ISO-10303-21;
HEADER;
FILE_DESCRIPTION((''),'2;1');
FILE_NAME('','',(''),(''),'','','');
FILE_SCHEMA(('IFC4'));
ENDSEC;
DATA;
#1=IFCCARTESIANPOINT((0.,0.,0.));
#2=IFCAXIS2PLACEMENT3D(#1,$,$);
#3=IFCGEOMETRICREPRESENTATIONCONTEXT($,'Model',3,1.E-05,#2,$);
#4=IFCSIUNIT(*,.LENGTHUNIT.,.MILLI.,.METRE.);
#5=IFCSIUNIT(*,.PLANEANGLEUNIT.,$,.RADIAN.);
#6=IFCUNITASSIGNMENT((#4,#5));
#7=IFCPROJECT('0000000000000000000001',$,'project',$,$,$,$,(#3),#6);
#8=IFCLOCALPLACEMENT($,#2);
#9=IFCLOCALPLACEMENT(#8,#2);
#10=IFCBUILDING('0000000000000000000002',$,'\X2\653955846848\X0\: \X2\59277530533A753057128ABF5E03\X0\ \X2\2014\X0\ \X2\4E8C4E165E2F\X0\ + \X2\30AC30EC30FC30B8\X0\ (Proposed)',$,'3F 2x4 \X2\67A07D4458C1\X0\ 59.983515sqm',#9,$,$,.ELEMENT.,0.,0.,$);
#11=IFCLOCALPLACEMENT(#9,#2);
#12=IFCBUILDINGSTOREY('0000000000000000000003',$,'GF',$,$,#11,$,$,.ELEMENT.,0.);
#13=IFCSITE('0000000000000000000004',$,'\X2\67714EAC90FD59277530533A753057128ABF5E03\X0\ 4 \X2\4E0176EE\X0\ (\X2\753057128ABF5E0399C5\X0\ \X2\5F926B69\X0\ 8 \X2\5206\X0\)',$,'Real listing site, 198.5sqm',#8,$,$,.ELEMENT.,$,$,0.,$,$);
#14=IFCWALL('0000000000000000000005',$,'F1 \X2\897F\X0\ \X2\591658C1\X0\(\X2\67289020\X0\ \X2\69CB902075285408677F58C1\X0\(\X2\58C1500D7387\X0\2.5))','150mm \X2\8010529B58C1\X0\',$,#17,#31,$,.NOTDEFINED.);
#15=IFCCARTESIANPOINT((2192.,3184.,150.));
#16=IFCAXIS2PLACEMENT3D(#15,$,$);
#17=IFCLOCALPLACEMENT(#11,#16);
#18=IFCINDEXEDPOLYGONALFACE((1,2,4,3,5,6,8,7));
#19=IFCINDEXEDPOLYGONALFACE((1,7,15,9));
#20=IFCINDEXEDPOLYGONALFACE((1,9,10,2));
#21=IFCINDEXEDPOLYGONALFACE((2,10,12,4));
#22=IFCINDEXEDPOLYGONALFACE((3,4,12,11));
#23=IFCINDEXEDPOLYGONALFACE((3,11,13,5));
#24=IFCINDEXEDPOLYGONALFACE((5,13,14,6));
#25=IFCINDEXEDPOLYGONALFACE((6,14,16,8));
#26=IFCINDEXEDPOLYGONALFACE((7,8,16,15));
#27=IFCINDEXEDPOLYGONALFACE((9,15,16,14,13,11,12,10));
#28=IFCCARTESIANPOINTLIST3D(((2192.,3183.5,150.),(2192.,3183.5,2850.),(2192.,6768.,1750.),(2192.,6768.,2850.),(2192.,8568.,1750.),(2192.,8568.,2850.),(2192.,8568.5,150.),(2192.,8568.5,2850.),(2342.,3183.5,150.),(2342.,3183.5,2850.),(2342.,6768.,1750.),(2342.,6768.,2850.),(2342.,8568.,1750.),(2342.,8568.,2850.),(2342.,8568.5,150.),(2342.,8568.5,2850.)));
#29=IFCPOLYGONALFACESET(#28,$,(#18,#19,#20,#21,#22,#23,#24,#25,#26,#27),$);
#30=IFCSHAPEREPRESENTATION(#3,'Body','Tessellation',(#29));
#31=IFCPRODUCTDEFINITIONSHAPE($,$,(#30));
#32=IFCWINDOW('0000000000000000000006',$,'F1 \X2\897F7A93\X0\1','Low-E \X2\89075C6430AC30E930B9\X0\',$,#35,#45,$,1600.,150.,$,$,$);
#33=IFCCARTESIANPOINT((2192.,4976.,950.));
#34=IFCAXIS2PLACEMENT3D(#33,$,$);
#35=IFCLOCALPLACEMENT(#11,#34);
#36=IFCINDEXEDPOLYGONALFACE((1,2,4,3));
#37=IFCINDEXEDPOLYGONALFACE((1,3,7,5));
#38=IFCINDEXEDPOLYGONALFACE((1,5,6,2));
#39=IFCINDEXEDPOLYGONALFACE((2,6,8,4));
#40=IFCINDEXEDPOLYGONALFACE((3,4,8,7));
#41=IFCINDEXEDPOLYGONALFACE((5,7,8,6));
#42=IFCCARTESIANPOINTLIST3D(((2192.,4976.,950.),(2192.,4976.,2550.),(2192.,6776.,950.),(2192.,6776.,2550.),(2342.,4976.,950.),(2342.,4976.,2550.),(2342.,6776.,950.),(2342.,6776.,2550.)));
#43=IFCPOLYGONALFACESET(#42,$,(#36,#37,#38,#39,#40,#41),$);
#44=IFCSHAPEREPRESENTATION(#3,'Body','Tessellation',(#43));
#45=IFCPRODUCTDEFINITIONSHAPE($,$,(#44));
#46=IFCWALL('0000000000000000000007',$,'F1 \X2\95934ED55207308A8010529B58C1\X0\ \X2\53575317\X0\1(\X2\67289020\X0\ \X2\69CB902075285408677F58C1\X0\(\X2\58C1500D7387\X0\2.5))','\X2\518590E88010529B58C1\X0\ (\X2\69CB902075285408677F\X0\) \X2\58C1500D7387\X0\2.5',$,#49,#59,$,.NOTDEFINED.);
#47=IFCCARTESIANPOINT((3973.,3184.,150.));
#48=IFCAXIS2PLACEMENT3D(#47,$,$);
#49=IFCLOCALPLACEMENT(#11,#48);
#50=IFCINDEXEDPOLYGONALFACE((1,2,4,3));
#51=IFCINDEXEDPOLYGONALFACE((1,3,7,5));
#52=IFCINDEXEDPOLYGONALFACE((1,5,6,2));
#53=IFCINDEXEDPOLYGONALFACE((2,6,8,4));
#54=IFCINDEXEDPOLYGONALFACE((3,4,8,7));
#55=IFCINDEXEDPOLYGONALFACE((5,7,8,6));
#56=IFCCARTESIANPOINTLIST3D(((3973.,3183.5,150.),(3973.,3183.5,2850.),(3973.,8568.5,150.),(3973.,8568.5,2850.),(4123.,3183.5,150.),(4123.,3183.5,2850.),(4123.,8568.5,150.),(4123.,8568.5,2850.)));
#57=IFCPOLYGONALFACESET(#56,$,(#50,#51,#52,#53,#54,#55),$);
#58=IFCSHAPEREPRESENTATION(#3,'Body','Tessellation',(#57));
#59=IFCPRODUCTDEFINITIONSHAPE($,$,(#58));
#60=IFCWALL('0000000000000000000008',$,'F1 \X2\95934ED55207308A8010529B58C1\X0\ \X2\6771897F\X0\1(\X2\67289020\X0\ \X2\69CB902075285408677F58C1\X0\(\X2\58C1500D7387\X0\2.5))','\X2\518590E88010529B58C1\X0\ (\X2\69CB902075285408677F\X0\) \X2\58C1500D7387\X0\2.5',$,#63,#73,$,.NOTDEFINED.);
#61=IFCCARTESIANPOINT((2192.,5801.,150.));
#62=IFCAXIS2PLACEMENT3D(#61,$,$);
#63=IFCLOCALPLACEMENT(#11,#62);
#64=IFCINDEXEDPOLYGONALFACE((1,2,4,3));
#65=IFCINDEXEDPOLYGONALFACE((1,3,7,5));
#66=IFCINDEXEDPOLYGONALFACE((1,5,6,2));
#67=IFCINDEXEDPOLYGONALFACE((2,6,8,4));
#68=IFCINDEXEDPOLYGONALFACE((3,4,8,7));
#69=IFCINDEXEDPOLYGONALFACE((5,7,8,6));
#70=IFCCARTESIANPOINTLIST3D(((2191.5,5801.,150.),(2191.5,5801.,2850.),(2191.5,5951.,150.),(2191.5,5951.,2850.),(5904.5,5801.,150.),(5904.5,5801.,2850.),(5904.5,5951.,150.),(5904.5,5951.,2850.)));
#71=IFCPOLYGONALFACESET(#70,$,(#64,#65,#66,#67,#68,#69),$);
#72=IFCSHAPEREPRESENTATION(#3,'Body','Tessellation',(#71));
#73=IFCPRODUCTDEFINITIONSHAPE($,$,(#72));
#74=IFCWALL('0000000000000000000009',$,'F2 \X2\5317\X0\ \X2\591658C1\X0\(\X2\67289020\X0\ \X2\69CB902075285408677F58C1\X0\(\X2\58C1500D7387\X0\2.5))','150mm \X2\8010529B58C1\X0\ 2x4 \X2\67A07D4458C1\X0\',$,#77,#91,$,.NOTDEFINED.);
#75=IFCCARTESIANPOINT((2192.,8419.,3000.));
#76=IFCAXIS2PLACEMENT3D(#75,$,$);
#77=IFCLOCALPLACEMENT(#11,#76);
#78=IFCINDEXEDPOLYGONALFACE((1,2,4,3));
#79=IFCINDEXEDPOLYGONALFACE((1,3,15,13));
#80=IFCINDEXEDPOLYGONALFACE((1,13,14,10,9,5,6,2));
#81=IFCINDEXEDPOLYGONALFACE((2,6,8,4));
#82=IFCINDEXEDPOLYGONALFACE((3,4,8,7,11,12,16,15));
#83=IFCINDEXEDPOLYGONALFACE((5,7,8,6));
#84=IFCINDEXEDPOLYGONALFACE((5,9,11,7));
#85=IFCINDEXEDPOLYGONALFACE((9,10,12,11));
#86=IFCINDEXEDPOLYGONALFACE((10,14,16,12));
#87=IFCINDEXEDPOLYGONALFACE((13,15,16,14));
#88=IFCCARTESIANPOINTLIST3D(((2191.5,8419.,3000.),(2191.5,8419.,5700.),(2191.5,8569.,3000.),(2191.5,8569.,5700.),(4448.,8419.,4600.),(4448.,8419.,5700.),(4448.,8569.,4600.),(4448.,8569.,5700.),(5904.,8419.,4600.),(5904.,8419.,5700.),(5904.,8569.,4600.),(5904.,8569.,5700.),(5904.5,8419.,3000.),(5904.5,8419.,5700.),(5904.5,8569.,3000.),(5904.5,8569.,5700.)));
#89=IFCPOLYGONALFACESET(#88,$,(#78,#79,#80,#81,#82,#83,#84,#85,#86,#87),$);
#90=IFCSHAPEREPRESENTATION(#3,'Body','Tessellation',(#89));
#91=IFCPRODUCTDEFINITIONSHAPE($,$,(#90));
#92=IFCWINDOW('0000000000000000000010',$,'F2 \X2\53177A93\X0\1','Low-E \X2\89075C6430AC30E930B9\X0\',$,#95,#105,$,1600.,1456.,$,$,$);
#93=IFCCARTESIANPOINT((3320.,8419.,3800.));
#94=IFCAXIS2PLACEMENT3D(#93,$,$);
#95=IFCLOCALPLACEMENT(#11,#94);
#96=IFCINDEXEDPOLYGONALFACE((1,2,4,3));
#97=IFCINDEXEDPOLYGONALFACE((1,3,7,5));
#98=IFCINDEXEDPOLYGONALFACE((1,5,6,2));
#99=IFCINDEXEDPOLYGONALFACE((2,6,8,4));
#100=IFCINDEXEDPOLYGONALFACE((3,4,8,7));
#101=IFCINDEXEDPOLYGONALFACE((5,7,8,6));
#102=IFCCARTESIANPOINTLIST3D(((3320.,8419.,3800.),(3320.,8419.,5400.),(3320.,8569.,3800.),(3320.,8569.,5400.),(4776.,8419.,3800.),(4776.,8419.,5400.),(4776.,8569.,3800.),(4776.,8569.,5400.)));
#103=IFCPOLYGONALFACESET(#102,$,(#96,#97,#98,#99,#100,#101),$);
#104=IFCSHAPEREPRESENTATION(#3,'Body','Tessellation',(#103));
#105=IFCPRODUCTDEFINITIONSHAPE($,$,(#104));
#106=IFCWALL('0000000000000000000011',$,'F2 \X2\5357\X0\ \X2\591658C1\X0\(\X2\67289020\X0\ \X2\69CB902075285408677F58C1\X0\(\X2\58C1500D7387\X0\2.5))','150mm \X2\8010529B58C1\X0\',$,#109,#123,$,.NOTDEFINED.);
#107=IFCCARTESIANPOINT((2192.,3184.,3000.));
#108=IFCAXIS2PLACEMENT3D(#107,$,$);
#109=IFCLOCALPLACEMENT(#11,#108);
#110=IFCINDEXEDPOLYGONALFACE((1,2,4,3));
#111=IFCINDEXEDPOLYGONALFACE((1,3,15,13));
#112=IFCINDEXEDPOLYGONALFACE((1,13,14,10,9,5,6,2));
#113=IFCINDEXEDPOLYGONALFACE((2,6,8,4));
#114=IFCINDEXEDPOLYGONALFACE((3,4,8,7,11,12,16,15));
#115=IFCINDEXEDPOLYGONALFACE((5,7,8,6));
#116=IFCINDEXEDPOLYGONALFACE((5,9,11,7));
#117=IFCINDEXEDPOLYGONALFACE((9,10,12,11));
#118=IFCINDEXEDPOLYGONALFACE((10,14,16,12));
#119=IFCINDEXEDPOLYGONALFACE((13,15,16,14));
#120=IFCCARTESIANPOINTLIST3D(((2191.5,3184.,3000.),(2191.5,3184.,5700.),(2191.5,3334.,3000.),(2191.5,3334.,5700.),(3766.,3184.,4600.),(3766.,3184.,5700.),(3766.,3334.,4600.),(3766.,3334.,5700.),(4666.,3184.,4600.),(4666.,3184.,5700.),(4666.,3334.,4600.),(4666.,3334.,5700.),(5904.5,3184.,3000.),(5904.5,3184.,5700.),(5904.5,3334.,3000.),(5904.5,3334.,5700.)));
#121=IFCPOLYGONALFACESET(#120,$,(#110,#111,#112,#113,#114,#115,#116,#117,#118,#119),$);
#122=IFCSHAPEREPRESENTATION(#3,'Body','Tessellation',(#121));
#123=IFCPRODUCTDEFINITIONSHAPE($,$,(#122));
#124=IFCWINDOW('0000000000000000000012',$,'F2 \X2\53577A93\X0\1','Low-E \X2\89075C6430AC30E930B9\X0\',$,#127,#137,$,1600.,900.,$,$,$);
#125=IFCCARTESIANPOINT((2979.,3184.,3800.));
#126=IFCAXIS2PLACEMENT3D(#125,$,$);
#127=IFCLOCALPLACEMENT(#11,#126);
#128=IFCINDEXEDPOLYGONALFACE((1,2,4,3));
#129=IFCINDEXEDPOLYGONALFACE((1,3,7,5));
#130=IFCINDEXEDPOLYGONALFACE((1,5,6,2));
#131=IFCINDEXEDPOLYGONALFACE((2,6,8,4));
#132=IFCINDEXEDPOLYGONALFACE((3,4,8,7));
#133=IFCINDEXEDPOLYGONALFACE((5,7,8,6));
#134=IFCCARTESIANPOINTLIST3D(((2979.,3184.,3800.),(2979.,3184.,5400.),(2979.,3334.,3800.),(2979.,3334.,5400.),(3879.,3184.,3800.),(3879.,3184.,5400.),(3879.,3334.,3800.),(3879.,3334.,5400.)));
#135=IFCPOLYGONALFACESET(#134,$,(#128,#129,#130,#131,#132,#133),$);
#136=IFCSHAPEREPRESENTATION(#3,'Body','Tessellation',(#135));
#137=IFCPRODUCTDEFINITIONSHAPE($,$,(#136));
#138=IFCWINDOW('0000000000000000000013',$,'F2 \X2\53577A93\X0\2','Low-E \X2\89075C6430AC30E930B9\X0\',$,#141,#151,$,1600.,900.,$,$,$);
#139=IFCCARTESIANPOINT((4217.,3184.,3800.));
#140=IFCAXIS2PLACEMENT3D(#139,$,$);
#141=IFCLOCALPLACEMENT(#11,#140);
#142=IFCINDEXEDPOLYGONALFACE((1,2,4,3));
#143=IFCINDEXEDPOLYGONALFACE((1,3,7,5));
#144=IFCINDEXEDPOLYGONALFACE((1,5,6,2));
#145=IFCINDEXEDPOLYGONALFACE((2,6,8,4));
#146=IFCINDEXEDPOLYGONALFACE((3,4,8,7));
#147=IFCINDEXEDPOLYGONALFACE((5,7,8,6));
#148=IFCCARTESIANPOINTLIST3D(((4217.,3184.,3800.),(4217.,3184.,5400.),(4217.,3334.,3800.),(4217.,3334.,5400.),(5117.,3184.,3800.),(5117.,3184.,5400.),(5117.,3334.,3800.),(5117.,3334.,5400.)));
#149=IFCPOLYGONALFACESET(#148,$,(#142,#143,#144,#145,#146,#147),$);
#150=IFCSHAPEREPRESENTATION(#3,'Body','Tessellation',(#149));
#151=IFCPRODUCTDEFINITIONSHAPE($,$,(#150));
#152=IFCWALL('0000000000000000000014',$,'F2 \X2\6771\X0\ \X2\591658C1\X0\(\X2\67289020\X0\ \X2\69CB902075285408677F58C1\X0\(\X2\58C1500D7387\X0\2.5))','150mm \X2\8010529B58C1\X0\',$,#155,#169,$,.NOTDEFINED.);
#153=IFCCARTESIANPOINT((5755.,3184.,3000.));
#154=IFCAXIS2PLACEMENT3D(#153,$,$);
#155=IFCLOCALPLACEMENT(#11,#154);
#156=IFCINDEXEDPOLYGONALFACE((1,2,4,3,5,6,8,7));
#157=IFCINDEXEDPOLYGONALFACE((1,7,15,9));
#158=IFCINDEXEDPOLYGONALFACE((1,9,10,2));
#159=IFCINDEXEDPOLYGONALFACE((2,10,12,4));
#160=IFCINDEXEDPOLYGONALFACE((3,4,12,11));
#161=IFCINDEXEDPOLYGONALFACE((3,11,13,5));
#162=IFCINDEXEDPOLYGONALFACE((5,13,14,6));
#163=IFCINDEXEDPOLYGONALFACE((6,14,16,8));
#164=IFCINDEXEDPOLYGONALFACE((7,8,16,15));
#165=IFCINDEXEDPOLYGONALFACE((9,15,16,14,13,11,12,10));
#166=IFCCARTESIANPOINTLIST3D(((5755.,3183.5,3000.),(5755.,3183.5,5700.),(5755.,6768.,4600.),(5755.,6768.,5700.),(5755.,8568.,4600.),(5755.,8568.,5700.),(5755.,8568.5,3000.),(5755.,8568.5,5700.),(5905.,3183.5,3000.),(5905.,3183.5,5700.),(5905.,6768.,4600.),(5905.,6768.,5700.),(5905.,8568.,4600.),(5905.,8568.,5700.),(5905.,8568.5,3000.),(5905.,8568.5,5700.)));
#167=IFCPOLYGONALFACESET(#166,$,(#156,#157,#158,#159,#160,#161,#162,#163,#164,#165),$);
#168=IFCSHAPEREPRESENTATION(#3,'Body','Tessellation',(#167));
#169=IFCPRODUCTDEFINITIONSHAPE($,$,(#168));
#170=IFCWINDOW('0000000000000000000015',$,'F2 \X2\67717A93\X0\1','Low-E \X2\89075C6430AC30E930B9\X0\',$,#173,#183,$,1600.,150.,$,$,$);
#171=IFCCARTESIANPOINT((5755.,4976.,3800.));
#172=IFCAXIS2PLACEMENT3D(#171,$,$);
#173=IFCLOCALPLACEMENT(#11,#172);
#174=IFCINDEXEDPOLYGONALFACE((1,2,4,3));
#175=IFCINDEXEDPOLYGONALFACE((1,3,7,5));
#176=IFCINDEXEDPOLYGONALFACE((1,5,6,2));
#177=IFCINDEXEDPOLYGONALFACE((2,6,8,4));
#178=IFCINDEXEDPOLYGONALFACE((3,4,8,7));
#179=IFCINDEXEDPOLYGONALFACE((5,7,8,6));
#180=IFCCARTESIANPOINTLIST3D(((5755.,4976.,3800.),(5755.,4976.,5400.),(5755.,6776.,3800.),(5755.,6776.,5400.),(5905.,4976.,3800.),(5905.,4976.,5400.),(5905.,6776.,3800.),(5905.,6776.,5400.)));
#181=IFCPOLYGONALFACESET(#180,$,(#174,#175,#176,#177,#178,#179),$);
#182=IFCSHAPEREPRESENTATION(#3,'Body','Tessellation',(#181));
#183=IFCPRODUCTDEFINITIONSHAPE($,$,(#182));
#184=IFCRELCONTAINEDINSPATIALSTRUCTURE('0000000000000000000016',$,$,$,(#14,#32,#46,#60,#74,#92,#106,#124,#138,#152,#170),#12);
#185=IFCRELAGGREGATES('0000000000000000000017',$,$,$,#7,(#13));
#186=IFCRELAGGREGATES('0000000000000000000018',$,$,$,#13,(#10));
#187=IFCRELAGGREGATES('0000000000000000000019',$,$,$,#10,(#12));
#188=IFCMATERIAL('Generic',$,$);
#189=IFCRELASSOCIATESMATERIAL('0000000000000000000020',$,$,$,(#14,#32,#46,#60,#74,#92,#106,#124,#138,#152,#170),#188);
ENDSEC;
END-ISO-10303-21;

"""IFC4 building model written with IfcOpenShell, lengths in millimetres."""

from ifc_helpers import new_model, si_unit, frame, frame_2d, origin, place, context, project, spatial, rectangle, extrude, material, element, fill, save


model = new_model("IFC4")

# Units and contexts
model_context = context("Model", 3, precision=1e-05, world=origin())
ifc_project = project(units=[si_unit("LENGTHUNIT", "METRE", prefix="MILLI"), si_unit("PLANEANGLEUNIT", "RADIAN")], contexts=[model_context])

# Site, building, storey
site_placement = place(None, origin())
site = spatial("IfcSite", under=ifc_project, at=site_placement, Name="東京都大田区田園調布 4 丁目 (田園調布駅 徒歩 8 分)", ObjectType="Real listing site, 198.5sqm", CompositionType="ELEMENT", RefElevation=0.0)
building_placement = place(site_placement, origin())
building = spatial("IfcBuilding", under=site, at=building_placement, Name="改善案: 大田区田園調布 — 二世帯 + ガレージ (Proposed)", ObjectType="3F 2x4 枠組壁 59.983515sqm", CompositionType="ELEMENT", ElevationOfRefHeight=0.0, ElevationOfTerrain=0.0)
storey_placement = place(building_placement, origin())
storey = spatial("IfcBuildingStorey", under=building, at=storey_placement, Name="GF", CompositionType="ELEMENT", Elevation=0.0)

# Shared definitions
ifc_material_1 = material(Name="Generic")

# Wall, opening, window
wall_1_placement = place(storey_placement, frame((2192.0, 3184.0, 150.0)))
wall_1 = element("IfcWall", 1, at=wall_1_placement, inside=storey, material=ifc_material_1, Name="F1 西 外壁(木造 構造用合板壁(壁倍率2.5))", Description="150mm 耐力壁", PredefinedType="NOTDEFINED", context=model_context, shape_type="SweptSolid", body=[
    extrude(rectangle(XDim=150.0, YDim=5385.0, at=frame_2d((75.0, 2692.0))), frame((2192.0, 3184.0, 150.0)), (0.0, 0.0, 1.0), 2700.0),
])
opening_1_placement = place(storey_placement, frame((2192.0, 4976.0, 950.0)))
opening_1 = element("IfcOpeningElement", 2, at=opening_1_placement, cuts=wall_1, PredefinedType="NOTDEFINED", context=model_context, shape_type="SweptSolid", body=[
    extrude(rectangle(XDim=150.0, YDim=1800.0, at=frame_2d((75.0, 900.0))), frame((2192.0, 4976.0, 950.0)), (0.0, 0.0, 1.0), 1600.0),
])
window_1_placement = place(storey_placement, frame((2192.0, 4976.0, 950.0)))
window_1 = element("IfcWindow", 3, at=window_1_placement, inside=storey, material=ifc_material_1, Name="F1 西窓1", Description="Low-E 複層ガラス", OverallHeight=1600.0, OverallWidth=150.0, context=model_context, shape_type="SweptSolid", body=[
    extrude(rectangle(XDim=150.0, YDim=1800.0, at=frame_2d((75.0, 900.0))), frame((2192.0, 4976.0, 950.0)), (0.0, 0.0, 1.0), 1600.0),
])
fill(opening_1, window_1)

# Walls
wall_2_placement = place(storey_placement, frame((3973.0, 3184.0, 150.0)))
element("IfcWall", 4, at=wall_2_placement, inside=storey, material=ifc_material_1, Name="F1 間仕切り耐力壁 南北1(木造 構造用合板壁(壁倍率2.5))", Description="内部耐力壁 (構造用合板) 壁倍率2.5", PredefinedType="NOTDEFINED", context=model_context, shape_type="SweptSolid", body=[
    extrude(rectangle(XDim=150.0, YDim=5385.0, at=frame_2d((75.0, 2692.0))), frame((3973.0, 3184.0, 150.0)), (0.0, 0.0, 1.0), 2700.0),
])
wall_3_placement = place(storey_placement, frame((2192.0, 5801.0, 150.0)))
element("IfcWall", 5, at=wall_3_placement, inside=storey, material=ifc_material_1, Name="F1 間仕切り耐力壁 東西1(木造 構造用合板壁(壁倍率2.5))", Description="内部耐力壁 (構造用合板) 壁倍率2.5", PredefinedType="NOTDEFINED", context=model_context, shape_type="SweptSolid", body=[
    extrude(rectangle(XDim=3713.0, YDim=150.0, at=frame_2d((1856.0, 75.0))), frame((2192.0, 5801.0, 150.0)), (0.0, 0.0, 1.0), 2700.0),
])

# Wall, opening, window
wall_4_placement = place(storey_placement, frame((2192.0, 8419.0, 3000.0)))
wall_4 = element("IfcWall", 6, at=wall_4_placement, inside=storey, material=ifc_material_1, Name="F2 北 外壁(木造 構造用合板壁(壁倍率2.5))", Description="150mm 耐力壁 2x4 枠組壁", PredefinedType="NOTDEFINED", context=model_context, shape_type="SweptSolid", body=[
    extrude(rectangle(XDim=3713.0, YDim=150.0, at=frame_2d((1856.0, 75.0))), frame((2192.0, 8419.0, 3000.0)), (0.0, 0.0, 1.0), 2700.0),
])
opening_2_placement = place(storey_placement, frame((3320.0, 8419.0, 3800.0)))
opening_2 = element("IfcOpeningElement", 7, at=opening_2_placement, cuts=wall_4, PredefinedType="NOTDEFINED", context=model_context, shape_type="SweptSolid", body=[
    extrude(rectangle(XDim=1456.0, YDim=150.0, at=frame_2d((728.0, 75.0))), frame((3320.0, 8419.0, 3800.0)), (0.0, 0.0, 1.0), 1600.0),
])
window_2_placement = place(storey_placement, frame((3320.0, 8419.0, 3800.0)))
window_2 = element("IfcWindow", 8, at=window_2_placement, inside=storey, material=ifc_material_1, Name="F2 北窓1", Description="Low-E 複層ガラス", OverallHeight=1600.0, OverallWidth=1456.0, context=model_context, shape_type="SweptSolid", body=[
    extrude(rectangle(XDim=1456.0, YDim=150.0, at=frame_2d((728.0, 75.0))), frame((3320.0, 8419.0, 3800.0)), (0.0, 0.0, 1.0), 1600.0),
])
fill(opening_2, window_2)

# Wall, openings, windows
wall_5_placement = place(storey_placement, frame((2192.0, 3184.0, 3000.0)))
wall_5 = element("IfcWall", 9, at=wall_5_placement, inside=storey, material=ifc_material_1, Name="F2 南 外壁(木造 構造用合板壁(壁倍率2.5))", Description="150mm 耐力壁", PredefinedType="NOTDEFINED", context=model_context, shape_type="SweptSolid", body=[
    extrude(rectangle(XDim=3713.0, YDim=150.0, at=frame_2d((1856.0, 75.0))), frame((2192.0, 3184.0, 3000.0)), (0.0, 0.0, 1.0), 2700.0),
])
opening_3_placement = place(storey_placement, frame((2979.0, 3184.0, 3800.0)))
opening_3 = element("IfcOpeningElement", 10, at=opening_3_placement, cuts=wall_5, PredefinedType="NOTDEFINED", context=model_context, shape_type="SweptSolid", body=[
    extrude(rectangle(XDim=900.0, YDim=150.0, at=frame_2d((450.0, 75.0))), frame((2979.0, 3184.0, 3800.0)), (0.0, 0.0, 1.0), 1600.0),
])
opening_4_placement = place(storey_placement, frame((4217.0, 3184.0, 3800.0)))
opening_4 = element("IfcOpeningElement", 11, at=opening_4_placement, cuts=wall_5, PredefinedType="NOTDEFINED", context=model_context, shape_type="SweptSolid", body=[
    extrude(rectangle(XDim=900.0, YDim=150.0, at=frame_2d((450.0, 75.0))), frame((4217.0, 3184.0, 3800.0)), (0.0, 0.0, 1.0), 1600.0),
])
window_3_placement = place(storey_placement, frame((2979.0, 3184.0, 3800.0)))
window_3 = element("IfcWindow", 12, at=window_3_placement, inside=storey, material=ifc_material_1, Name="F2 南窓1", Description="Low-E 複層ガラス", OverallHeight=1600.0, OverallWidth=900.0, context=model_context, shape_type="SweptSolid", body=[
    extrude(rectangle(XDim=900.0, YDim=150.0, at=frame_2d((450.0, 75.0))), frame((2979.0, 3184.0, 3800.0)), (0.0, 0.0, 1.0), 1600.0),
])
fill(opening_3, window_3)
window_4_placement = place(storey_placement, frame((4217.0, 3184.0, 3800.0)))
window_4 = element("IfcWindow", 13, at=window_4_placement, inside=storey, material=ifc_material_1, Name="F2 南窓2", Description="Low-E 複層ガラス", OverallHeight=1600.0, OverallWidth=900.0, context=model_context, shape_type="SweptSolid", body=[
    extrude(rectangle(XDim=900.0, YDim=150.0, at=frame_2d((450.0, 75.0))), frame((4217.0, 3184.0, 3800.0)), (0.0, 0.0, 1.0), 1600.0),
])
fill(opening_4, window_4)

# Wall, opening, window
wall_6_placement = place(storey_placement, frame((5755.0, 3184.0, 3000.0)))
wall_6 = element("IfcWall", 14, at=wall_6_placement, inside=storey, material=ifc_material_1, Name="F2 東 外壁(木造 構造用合板壁(壁倍率2.5))", Description="150mm 耐力壁", PredefinedType="NOTDEFINED", context=model_context, shape_type="SweptSolid", body=[
    extrude(rectangle(XDim=150.0, YDim=5385.0, at=frame_2d((75.0, 2692.0))), frame((5755.0, 3184.0, 3000.0)), (0.0, 0.0, 1.0), 2700.0),
])
opening_5_placement = place(storey_placement, frame((5755.0, 4976.0, 3800.0)))
opening_5 = element("IfcOpeningElement", 15, at=opening_5_placement, cuts=wall_6, PredefinedType="NOTDEFINED", context=model_context, shape_type="SweptSolid", body=[
    extrude(rectangle(XDim=150.0, YDim=1800.0, at=frame_2d((75.0, 900.0))), frame((5755.0, 4976.0, 3800.0)), (0.0, 0.0, 1.0), 1600.0),
])
window_5_placement = place(storey_placement, frame((5755.0, 4976.0, 3800.0)))
window_5 = element("IfcWindow", 16, at=window_5_placement, inside=storey, material=ifc_material_1, Name="F2 東窓1", Description="Low-E 複層ガラス", OverallHeight=1600.0, OverallWidth=150.0, context=model_context, shape_type="SweptSolid", body=[
    extrude(rectangle(XDim=150.0, YDim=1800.0, at=frame_2d((75.0, 900.0))), frame((5755.0, 4976.0, 3800.0)), (0.0, 0.0, 1.0), 1600.0),
])
fill(opening_5, window_5)

save(model, "model.ifc")
